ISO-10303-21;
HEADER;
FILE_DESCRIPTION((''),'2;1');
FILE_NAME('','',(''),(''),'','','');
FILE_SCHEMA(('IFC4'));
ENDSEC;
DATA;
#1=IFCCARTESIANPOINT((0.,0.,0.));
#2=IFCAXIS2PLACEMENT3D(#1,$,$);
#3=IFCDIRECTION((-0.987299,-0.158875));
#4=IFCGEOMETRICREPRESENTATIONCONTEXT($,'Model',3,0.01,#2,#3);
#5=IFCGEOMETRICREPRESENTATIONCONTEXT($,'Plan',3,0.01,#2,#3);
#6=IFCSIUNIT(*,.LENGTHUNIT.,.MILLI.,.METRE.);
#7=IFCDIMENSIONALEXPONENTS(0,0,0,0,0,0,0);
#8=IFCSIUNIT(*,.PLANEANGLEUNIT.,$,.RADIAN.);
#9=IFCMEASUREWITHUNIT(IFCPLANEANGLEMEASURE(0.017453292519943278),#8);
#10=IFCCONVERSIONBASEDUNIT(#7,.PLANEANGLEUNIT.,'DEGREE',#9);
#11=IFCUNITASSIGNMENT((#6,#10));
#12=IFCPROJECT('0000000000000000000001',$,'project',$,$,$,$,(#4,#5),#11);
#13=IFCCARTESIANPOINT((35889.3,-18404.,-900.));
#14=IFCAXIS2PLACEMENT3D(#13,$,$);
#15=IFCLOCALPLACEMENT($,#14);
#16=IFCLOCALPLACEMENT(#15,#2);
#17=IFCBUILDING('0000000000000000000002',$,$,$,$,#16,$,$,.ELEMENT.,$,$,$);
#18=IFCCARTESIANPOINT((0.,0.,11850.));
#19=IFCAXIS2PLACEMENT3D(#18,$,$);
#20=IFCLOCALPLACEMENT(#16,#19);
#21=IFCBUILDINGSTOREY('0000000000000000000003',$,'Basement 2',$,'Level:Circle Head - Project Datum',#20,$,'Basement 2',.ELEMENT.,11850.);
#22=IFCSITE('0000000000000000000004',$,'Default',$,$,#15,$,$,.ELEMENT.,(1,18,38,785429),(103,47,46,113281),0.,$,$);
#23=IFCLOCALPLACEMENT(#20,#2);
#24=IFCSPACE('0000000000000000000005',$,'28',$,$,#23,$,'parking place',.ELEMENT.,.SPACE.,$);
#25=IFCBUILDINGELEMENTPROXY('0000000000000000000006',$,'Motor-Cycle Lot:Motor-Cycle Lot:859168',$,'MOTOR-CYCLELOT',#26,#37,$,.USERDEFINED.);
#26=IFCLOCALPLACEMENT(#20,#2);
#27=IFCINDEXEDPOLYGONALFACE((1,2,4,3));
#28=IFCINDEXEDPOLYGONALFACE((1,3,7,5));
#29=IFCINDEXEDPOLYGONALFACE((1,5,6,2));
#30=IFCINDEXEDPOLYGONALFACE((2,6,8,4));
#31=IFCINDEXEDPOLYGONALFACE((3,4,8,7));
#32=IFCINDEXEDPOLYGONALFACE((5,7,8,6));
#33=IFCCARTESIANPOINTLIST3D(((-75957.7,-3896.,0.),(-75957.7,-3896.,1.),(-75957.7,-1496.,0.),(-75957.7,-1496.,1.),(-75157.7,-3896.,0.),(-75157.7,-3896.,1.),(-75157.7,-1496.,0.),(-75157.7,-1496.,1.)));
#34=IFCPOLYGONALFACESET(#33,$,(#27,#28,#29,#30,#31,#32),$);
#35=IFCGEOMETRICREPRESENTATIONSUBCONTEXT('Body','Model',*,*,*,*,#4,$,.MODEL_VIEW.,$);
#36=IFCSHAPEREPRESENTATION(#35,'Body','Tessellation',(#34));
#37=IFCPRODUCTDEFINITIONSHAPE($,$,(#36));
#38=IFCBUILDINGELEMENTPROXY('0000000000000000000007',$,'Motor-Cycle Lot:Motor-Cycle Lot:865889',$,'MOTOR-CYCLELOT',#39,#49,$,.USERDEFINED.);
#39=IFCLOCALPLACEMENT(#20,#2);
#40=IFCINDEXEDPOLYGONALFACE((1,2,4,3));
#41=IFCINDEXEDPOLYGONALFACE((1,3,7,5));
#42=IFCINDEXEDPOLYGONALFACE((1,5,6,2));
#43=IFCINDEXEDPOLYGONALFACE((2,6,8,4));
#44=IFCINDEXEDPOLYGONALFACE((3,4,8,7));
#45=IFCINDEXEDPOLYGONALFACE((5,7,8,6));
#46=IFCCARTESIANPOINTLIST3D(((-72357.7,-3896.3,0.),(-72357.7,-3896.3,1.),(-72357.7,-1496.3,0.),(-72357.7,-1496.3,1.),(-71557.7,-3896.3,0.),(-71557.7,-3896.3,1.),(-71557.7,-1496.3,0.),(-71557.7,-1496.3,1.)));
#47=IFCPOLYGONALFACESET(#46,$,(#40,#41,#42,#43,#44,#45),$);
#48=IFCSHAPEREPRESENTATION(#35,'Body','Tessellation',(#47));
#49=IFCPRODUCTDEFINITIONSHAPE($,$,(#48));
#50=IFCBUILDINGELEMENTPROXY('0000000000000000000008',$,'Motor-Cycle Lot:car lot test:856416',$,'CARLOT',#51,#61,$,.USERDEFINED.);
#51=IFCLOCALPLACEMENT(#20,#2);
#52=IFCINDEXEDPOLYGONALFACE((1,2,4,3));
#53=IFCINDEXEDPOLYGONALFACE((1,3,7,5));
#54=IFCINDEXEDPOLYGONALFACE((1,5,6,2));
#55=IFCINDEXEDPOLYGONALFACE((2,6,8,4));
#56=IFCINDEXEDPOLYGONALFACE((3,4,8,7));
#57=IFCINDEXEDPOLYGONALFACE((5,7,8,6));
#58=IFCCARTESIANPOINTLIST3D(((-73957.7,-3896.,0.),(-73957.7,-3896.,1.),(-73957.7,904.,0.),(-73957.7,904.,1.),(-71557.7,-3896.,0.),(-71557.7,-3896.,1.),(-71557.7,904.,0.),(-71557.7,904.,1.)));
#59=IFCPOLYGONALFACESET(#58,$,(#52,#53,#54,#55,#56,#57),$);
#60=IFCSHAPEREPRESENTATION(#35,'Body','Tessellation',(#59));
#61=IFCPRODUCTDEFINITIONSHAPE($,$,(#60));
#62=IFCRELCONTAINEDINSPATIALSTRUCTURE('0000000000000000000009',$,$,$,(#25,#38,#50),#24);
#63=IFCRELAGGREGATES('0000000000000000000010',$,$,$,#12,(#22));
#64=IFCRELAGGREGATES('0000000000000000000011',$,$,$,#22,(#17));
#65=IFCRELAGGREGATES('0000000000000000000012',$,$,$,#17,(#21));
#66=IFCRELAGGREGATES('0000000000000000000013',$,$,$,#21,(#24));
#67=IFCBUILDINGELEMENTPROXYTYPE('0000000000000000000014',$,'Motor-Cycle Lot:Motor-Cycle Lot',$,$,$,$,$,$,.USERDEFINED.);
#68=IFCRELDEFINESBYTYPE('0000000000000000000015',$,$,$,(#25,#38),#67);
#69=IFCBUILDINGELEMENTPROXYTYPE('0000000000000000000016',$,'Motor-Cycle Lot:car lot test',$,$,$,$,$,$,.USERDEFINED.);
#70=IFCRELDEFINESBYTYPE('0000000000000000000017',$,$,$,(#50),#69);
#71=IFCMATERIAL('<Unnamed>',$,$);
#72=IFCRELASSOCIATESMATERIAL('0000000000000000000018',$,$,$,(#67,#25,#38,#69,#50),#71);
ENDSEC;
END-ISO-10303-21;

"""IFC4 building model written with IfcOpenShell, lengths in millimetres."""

from ifc_helpers import new_model, entity, si_unit, converted_unit, direction, frame, origin, place, context, subcontext, project, spatial, indexed_curve, outline, extrude, source, transform, mapped, material, type_object, type_shapes, element, save


model = new_model("IFC4")

# Units and contexts
model_context = context("Model", 3, precision=0.01, world=origin(), true_north=direction((-0.987299, -0.158875)))
plan_context = context("Plan", 3, precision=0.01, world=origin(), true_north=direction((-0.987299, -0.158875)))
body_context = subcontext(model_context, "Body", "Model", "MODEL_VIEW")
ifc_project = project(units=[si_unit("LENGTHUNIT", "METRE", prefix="MILLI"), converted_unit("PLANEANGLEUNIT", "DEGREE", entity("IfcPlaneAngleMeasure", 0.017453292519943278), si_unit("PLANEANGLEUNIT", "RADIAN"), dimensions=[0, 0, 0, 0, 0, 0, 0])], contexts=[model_context, plan_context])

# Site, building, storey
site_placement = place(None, frame((35889.3, -18404.0, -900.0)))
site = spatial("IfcSite", under=ifc_project, at=site_placement, Name="Default", CompositionType="ELEMENT", RefLatitude=(1, 18, 38, 785429), RefLongitude=(103, 47, 46, 113281), RefElevation=0.0)
building_placement = place(site_placement, origin())
building = spatial("IfcBuilding", under=site, at=building_placement, CompositionType="ELEMENT")
storey_placement = place(building_placement, frame((0.0, 0.0, 11850.0)))
storey = spatial("IfcBuildingStorey", under=building, at=storey_placement, Name="Basement 2", ObjectType="Level:Circle Head - Project Datum", LongName="Basement 2", CompositionType="ELEMENT", Elevation=11850.0)

# Shared definitions
ifc_material_1 = material(Name="<Unnamed>")

# Shared definitions
space_1_placement = place(storey_placement, origin())
space_1 = spatial("IfcSpace", under=storey, at=space_1_placement, Name="28", LongName="parking place", CompositionType="ELEMENT", PredefinedType="SPACE")

# Building element proxies
building_element_proxy_type_1 = type_object("IfcBuildingElementProxyType", Name="Motor-Cycle Lot:Motor-Cycle Lot", PredefinedType="USERDEFINED", material=ifc_material_1)
shared_shape_1 = source(origin(), body_context, "Body", "SweptSolid", [
    extrude(outline(indexed_curve([(-400.0, -1200.0), (400.0, -1200.0), (400.0, 1200.0), (-400.0, 1200.0), (-400.0, -1200.0)], self_intersect=False)), frame((0.0, 0.0, 0.0), z_axis=(0.0, 0.0, 1.0), x_axis=(-1.0, 0.0, 0.0)), (0.0, 0.0, 1.0), 1.0),
])
type_shapes(building_element_proxy_type_1, [shared_shape_1])
for number, where, z_axis, x_axis, name in (
    (1, (-75557.7, -2696.0, 0.0), (0.0, 0.0, 1.0), (-1.0, 0.0, 0.0), "Motor-Cycle Lot:Motor-Cycle Lot:859168"),
    (2, (-71957.7, -2696.3, 0.0), (0.0, 0.0, 1.0), (-1.0, 0.0, 0.0), "Motor-Cycle Lot:Motor-Cycle Lot:865889"),
):
    element("IfcBuildingElementProxy", number, at=place(space_1_placement, frame(where, z_axis=z_axis, x_axis=x_axis)), inside=space_1, type_object=building_element_proxy_type_1, material=ifc_material_1, Name=name, ObjectType="MOTOR-CYCLELOT", PredefinedType="USERDEFINED", context=body_context, shape_type="MappedRepresentation", body=[
        mapped(shared_shape_1, transform((0.0, 0.0, 0.0), scale=1.0)),
    ])
building_element_proxy_type_2 = type_object("IfcBuildingElementProxyType", Name="Motor-Cycle Lot:car lot test", PredefinedType="USERDEFINED", material=ifc_material_1)
shared_shape_2 = source(origin(), body_context, "Body", "SweptSolid", [
    extrude(outline(indexed_curve([(-2400.0, -1200.0), (2400.0, -1200.0), (2400.0, 1200.0), (-2400.0, 1200.0), (-2400.0, -1200.0)], self_intersect=False)), frame((0.0, 0.0, 0.0), z_axis=(0.0, 0.0, 1.0), x_axis=(-1.0, 0.0, 0.0)), (0.0, 0.0, 1.0), 1.0),
])
type_shapes(building_element_proxy_type_2, [shared_shape_2])
proxy_1_placement = place(space_1_placement, frame((-72757.7, -1496.0, 0.0), z_axis=(0.0, 0.0, 1.0), x_axis=(0.0, -1.0, 0.0)))
element("IfcBuildingElementProxy", 3, at=proxy_1_placement, inside=space_1, type_object=building_element_proxy_type_2, material=ifc_material_1, Name="Motor-Cycle Lot:car lot test:856416", ObjectType="CARLOT", PredefinedType="USERDEFINED", context=body_context, shape_type="MappedRepresentation", body=[
    mapped(shared_shape_2, transform((0.0, 0.0, 0.0), scale=1.0)),
])

save(model, "model.ifc")
